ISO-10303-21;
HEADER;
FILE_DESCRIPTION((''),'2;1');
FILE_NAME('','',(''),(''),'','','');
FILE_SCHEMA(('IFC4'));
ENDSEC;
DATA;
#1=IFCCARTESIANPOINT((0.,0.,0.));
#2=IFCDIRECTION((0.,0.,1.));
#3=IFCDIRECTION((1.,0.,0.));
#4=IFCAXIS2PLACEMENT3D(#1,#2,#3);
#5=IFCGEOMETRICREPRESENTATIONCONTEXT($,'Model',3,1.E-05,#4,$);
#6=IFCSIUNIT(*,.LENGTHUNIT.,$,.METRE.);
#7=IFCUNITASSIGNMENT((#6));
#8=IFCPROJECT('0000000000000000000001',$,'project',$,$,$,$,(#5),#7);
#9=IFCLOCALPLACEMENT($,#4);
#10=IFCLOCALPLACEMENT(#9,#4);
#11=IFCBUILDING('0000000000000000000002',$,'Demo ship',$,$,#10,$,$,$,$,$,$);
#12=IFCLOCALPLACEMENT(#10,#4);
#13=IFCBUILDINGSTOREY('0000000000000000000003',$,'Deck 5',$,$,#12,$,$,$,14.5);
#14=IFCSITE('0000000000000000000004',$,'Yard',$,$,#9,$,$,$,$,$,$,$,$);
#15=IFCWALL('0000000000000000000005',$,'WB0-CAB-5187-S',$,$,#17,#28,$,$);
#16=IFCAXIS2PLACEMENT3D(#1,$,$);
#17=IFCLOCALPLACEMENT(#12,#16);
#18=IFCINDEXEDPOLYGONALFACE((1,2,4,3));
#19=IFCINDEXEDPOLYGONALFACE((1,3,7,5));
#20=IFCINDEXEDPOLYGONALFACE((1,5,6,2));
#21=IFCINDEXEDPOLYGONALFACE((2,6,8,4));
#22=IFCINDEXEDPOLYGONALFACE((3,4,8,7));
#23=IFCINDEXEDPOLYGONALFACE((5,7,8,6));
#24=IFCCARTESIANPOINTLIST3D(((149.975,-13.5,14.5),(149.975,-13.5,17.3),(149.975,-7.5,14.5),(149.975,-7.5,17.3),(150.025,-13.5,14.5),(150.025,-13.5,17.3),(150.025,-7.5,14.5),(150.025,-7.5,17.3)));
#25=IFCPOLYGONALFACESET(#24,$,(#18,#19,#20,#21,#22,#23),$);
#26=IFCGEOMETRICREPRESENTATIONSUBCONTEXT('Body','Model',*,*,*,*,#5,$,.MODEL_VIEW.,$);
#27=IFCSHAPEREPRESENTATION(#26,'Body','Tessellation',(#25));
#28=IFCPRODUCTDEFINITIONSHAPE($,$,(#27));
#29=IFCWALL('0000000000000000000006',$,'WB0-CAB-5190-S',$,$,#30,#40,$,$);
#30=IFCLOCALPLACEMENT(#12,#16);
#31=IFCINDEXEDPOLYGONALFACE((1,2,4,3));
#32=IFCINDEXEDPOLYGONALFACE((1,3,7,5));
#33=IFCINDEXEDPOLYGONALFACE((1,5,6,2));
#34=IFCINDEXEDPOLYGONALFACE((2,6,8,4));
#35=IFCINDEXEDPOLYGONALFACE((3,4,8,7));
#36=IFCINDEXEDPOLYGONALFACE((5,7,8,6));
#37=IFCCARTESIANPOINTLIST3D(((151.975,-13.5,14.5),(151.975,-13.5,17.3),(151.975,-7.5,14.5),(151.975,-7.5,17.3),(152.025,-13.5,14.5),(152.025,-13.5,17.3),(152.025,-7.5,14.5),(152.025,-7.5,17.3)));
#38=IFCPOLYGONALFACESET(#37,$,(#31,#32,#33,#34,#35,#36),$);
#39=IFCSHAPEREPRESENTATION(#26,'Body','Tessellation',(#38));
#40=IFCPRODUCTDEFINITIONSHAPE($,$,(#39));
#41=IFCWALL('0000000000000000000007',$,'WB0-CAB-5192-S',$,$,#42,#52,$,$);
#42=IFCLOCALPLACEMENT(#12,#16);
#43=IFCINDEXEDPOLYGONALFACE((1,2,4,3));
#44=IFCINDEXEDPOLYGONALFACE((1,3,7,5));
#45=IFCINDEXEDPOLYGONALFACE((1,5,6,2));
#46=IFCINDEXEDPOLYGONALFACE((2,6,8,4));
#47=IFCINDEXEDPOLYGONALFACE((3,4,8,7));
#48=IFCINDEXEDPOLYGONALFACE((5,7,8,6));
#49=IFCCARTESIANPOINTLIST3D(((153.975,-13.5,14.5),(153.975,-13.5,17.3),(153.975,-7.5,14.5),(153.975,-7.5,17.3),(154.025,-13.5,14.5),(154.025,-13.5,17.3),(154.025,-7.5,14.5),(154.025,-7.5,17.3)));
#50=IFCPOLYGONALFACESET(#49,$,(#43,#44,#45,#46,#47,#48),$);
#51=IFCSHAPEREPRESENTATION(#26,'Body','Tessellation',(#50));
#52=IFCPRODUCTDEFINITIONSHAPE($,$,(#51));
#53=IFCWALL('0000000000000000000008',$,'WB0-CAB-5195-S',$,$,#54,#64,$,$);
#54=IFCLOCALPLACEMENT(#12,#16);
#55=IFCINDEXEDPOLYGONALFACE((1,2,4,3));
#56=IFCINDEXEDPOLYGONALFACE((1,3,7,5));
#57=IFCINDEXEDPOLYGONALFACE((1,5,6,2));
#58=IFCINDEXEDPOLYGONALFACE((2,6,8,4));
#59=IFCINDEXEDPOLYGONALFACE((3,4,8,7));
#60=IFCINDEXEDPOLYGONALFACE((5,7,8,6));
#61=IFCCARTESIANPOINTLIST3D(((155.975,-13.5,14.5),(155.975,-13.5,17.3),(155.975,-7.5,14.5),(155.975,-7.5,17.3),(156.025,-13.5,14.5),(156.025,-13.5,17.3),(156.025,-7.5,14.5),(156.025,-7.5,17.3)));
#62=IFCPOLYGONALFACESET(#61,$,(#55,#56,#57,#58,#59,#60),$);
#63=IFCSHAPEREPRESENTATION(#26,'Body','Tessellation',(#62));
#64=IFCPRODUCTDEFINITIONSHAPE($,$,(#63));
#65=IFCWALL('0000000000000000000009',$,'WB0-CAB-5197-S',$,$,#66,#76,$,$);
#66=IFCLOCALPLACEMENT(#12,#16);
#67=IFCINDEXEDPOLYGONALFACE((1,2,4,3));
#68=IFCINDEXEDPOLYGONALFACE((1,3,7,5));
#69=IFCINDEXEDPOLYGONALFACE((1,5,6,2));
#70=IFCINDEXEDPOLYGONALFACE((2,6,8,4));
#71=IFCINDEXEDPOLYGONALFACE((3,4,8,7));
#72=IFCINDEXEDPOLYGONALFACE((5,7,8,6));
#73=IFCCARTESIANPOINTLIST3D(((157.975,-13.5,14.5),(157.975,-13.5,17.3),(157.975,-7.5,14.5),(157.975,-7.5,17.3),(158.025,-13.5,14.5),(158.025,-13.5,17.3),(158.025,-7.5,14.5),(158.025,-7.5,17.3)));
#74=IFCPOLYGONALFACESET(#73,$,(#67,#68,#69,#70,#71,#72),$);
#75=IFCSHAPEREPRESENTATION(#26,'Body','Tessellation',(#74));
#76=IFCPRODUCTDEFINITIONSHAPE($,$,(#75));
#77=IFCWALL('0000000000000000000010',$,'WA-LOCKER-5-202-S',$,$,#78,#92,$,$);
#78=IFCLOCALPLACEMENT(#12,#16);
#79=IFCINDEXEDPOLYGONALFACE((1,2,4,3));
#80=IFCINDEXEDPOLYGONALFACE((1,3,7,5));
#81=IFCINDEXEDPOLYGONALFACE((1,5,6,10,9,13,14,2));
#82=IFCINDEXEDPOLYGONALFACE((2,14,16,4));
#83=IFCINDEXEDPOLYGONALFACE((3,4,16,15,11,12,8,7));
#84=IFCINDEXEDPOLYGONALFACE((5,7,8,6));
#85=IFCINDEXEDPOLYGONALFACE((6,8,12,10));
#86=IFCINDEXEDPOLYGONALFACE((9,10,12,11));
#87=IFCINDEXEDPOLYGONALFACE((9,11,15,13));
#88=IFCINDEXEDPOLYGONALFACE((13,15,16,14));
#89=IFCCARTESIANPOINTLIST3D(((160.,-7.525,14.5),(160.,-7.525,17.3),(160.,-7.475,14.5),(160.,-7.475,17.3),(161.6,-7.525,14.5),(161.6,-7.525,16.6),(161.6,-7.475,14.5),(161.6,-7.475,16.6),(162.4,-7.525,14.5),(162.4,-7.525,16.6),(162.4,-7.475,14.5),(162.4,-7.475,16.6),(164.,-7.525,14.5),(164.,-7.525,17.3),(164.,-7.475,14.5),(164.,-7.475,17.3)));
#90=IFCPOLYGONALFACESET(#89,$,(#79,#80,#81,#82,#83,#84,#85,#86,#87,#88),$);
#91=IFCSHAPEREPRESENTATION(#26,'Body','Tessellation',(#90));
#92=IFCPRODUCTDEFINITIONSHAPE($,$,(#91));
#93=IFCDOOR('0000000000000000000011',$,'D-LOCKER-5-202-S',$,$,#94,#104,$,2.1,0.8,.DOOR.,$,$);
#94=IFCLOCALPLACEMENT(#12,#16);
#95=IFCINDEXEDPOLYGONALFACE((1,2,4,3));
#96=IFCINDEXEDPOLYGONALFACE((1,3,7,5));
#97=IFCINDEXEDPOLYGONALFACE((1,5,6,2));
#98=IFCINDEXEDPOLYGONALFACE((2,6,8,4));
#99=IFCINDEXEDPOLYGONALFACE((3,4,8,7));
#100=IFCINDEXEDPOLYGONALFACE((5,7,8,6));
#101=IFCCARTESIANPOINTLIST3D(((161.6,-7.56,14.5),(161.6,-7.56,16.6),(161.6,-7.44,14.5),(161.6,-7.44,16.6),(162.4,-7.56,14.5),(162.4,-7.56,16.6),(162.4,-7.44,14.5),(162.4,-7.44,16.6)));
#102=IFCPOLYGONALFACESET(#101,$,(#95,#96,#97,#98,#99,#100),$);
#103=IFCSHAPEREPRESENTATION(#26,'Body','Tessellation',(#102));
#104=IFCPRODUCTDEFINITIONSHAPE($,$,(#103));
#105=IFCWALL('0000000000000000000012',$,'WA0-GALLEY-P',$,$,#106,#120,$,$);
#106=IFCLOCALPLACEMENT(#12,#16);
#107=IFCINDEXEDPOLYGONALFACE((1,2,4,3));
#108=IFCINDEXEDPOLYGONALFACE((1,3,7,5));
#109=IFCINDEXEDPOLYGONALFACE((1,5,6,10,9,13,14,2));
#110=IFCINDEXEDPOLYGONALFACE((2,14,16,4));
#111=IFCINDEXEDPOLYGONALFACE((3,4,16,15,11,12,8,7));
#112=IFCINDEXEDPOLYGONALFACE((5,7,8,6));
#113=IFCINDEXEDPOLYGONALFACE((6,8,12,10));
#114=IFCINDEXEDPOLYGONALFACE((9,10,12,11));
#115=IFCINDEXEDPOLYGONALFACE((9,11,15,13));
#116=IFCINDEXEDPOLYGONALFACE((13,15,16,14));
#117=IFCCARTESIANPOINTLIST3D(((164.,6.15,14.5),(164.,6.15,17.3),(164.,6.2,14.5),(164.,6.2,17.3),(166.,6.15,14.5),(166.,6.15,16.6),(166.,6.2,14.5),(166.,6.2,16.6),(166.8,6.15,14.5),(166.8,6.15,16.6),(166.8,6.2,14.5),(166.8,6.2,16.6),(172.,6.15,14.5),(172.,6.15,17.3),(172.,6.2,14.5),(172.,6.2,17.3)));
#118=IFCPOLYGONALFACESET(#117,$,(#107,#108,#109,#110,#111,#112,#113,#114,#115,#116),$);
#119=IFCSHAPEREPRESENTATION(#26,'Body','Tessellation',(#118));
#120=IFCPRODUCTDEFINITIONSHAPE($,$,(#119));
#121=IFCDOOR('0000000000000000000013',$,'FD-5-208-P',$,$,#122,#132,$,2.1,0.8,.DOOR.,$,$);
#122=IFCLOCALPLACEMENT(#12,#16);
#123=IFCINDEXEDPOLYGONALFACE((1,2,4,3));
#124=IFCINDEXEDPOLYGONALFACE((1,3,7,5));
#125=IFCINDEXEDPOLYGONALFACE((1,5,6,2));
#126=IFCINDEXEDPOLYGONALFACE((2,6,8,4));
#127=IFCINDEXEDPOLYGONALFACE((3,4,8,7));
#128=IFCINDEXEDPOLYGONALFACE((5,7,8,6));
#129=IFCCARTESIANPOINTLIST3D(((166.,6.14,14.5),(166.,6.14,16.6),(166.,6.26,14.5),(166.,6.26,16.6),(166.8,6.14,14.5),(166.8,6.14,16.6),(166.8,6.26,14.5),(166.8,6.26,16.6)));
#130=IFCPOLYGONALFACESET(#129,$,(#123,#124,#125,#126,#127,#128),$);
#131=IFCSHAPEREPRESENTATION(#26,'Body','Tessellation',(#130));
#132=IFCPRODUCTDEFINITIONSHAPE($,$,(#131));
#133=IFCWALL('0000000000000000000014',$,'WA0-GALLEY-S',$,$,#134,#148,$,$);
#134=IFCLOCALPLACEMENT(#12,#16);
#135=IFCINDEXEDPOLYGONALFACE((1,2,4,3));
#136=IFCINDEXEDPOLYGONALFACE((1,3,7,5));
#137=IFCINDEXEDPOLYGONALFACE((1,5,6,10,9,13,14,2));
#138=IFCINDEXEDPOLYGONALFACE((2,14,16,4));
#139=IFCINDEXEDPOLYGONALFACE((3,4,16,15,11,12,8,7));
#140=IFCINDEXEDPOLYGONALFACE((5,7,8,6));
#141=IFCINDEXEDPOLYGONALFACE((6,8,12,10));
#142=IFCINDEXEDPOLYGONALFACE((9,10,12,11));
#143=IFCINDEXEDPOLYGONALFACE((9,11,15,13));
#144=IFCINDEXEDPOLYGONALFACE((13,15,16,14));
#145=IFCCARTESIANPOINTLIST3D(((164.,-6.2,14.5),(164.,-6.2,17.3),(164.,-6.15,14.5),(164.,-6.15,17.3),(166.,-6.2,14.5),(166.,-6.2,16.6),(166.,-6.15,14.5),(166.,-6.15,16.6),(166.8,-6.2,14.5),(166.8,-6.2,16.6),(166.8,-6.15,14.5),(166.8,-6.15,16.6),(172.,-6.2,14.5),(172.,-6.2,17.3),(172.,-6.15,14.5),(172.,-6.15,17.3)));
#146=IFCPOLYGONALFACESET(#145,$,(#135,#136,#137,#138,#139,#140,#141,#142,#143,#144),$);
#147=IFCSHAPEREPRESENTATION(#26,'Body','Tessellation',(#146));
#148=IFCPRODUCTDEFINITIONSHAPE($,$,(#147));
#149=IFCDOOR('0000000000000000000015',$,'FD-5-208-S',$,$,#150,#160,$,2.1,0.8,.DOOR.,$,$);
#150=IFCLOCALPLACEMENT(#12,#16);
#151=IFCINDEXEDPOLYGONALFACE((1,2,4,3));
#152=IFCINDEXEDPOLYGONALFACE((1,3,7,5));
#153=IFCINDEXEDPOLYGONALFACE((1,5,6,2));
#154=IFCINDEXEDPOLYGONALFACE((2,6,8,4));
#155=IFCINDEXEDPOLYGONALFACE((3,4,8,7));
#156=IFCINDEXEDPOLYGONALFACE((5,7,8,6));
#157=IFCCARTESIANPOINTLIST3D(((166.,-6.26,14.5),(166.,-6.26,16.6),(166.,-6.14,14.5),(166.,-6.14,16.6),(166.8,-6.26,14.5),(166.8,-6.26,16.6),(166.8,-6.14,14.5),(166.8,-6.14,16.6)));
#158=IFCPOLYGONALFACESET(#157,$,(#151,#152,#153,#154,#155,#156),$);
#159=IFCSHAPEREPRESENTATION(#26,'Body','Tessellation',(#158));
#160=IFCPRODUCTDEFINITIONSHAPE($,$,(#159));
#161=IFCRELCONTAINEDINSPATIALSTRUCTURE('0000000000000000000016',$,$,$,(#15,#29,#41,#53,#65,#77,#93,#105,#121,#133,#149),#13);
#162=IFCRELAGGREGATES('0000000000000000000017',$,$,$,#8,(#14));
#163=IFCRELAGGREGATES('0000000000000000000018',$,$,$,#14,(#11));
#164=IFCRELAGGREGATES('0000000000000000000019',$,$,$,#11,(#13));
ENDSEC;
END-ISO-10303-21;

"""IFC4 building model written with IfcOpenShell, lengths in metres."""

from ifc_helpers import new_model, si_unit, frame, frame_2d, origin, origin_with_axes, place, context, subcontext, project, spatial, rectangle, extrude, element, fill, save


model = new_model("IFC4")

# Units and contexts
model_context = context("Model", 3, precision=1e-05, world=origin_with_axes())
body_context = subcontext(model_context, "Body", "Model", "MODEL_VIEW")
ifc_project = project(units=[si_unit("LENGTHUNIT", "METRE")], contexts=[model_context])

# Site, building, storey
site_placement = place(None, origin_with_axes())
site = spatial("IfcSite", under=ifc_project, at=site_placement, Name="Yard")
building_placement = place(site_placement, origin_with_axes())
building = spatial("IfcBuilding", under=site, at=building_placement, Name="Demo ship")
storey_placement = place(building_placement, origin_with_axes())
storey = spatial("IfcBuildingStorey", under=building, at=storey_placement, Name="Deck 5", Elevation=14.5)

# Walls
for number, where, z_axis, x_axis, name in (
    (1, (149.975, -13.5, 14.5), (0.0, 0.0, 1.0), (1.0, 0.0, 0.0), "WB0-CAB-5187-S"),
    (2, (151.975, -13.5, 14.5), (0.0, 0.0, 1.0), (1.0, 0.0, 0.0), "WB0-CAB-5190-S"),
    (3, (153.975, -13.5, 14.5), (0.0, 0.0, 1.0), (1.0, 0.0, 0.0), "WB0-CAB-5192-S"),
    (4, (155.975, -13.5, 14.5), (0.0, 0.0, 1.0), (1.0, 0.0, 0.0), "WB0-CAB-5195-S"),
    (5, (157.975, -13.5, 14.5), (0.0, 0.0, 1.0), (1.0, 0.0, 0.0), "WB0-CAB-5197-S"),
):
    element("IfcWall", number, at=place(storey_placement, frame(where, z_axis=z_axis, x_axis=x_axis)), inside=storey, Name=name, context=body_context, shape_type="SweptSolid", body=[
        extrude(rectangle(XDim=0.05, YDim=6.0, at=frame_2d((0.025, 3.0))), origin(), (0.0, 0.0, 1.0), 2.8),
    ])

# Walls, openings, doors
wall_1_placement = place(storey_placement, frame((160.0, -7.525, 14.5), z_axis=(0.0, 0.0, 1.0), x_axis=(1.0, 0.0, 0.0)))
wall_1 = element("IfcWall", 6, at=wall_1_placement, inside=storey, Name="WA-LOCKER-5-202-S", context=body_context, shape_type="SweptSolid", body=[
    extrude(rectangle(XDim=4.0, YDim=0.05, at=frame_2d((2.0, 0.025))), origin(), (0.0, 0.0, 1.0), 2.8),
])
opening_1_placement = place(None, frame((161.6, -7.56, 14.5), z_axis=(0.0, 0.0, 1.0), x_axis=(1.0, 0.0, 0.0)))
opening_1 = element("IfcOpeningElement", 7, at=opening_1_placement, cuts=wall_1, context=body_context, shape_type="SweptSolid", body=[
    extrude(rectangle(XDim=0.8, YDim=0.12, at=frame_2d((0.4, 0.06))), origin(), (0.0, 0.0, 1.0), 2.1),
])
door_1_placement = place(storey_placement, frame((161.6, -7.56, 14.5), z_axis=(0.0, 0.0, 1.0), x_axis=(1.0, 0.0, 0.0)))
door_1 = element("IfcDoor", 8, at=door_1_placement, inside=storey, Name="D-LOCKER-5-202-S", OverallHeight=2.1, OverallWidth=0.8, PredefinedType="DOOR", context=body_context, shape_type="SweptSolid", body=[
    extrude(rectangle(XDim=0.8, YDim=0.12, at=frame_2d((0.4, 0.06))), origin(), (0.0, 0.0, 1.0), 2.1),
])
fill(opening_1, door_1)
wall_2_placement = place(storey_placement, frame((164.0, 6.15, 14.5), z_axis=(0.0, 0.0, 1.0), x_axis=(1.0, 0.0, 0.0)))
wall_2 = element("IfcWall", 9, at=wall_2_placement, inside=storey, Name="WA0-GALLEY-P", context=body_context, shape_type="SweptSolid", body=[
    extrude(rectangle(XDim=8.0, YDim=0.05, at=frame_2d((4.0, 0.025))), origin(), (0.0, 0.0, 1.0), 2.8),
])
opening_2_placement = place(None, frame((166.0, 6.14, 14.5), z_axis=(0.0, 0.0, 1.0), x_axis=(1.0, 0.0, 0.0)))
opening_2 = element("IfcOpeningElement", 10, at=opening_2_placement, cuts=wall_2, context=body_context, shape_type="SweptSolid", body=[
    extrude(rectangle(XDim=0.8, YDim=0.12, at=frame_2d((0.4, 0.06))), origin(), (0.0, 0.0, 1.0), 2.1),
])
door_2_placement = place(storey_placement, frame((166.0, 6.14, 14.5), z_axis=(0.0, 0.0, 1.0), x_axis=(1.0, 0.0, 0.0)))
door_2 = element("IfcDoor", 11, at=door_2_placement, inside=storey, Name="FD-5-208-P", OverallHeight=2.1, OverallWidth=0.8, PredefinedType="DOOR", context=body_context, shape_type="SweptSolid", body=[
    extrude(rectangle(XDim=0.8, YDim=0.12, at=frame_2d((0.4, 0.06))), origin(), (0.0, 0.0, 1.0), 2.1),
])
fill(opening_2, door_2)
wall_3_placement = place(storey_placement, frame((164.0, -6.2, 14.5), z_axis=(0.0, 0.0, 1.0), x_axis=(1.0, 0.0, 0.0)))
wall_3 = element("IfcWall", 12, at=wall_3_placement, inside=storey, Name="WA0-GALLEY-S", context=body_context, shape_type="SweptSolid", body=[
    extrude(rectangle(XDim=8.0, YDim=0.05, at=frame_2d((4.0, 0.025))), origin(), (0.0, 0.0, 1.0), 2.8),
])
opening_3_placement = place(None, frame((166.0, -6.26, 14.5), z_axis=(0.0, 0.0, 1.0), x_axis=(1.0, 0.0, 0.0)))
opening_3 = element("IfcOpeningElement", 13, at=opening_3_placement, cuts=wall_3, context=body_context, shape_type="SweptSolid", body=[
    extrude(rectangle(XDim=0.8, YDim=0.12, at=frame_2d((0.4, 0.06))), origin(), (0.0, 0.0, 1.0), 2.1),
])
door_3_placement = place(storey_placement, frame((166.0, -6.26, 14.5), z_axis=(0.0, 0.0, 1.0), x_axis=(1.0, 0.0, 0.0)))
door_3 = element("IfcDoor", 14, at=door_3_placement, inside=storey, Name="FD-5-208-S", OverallHeight=2.1, OverallWidth=0.8, PredefinedType="DOOR", context=body_context, shape_type="SweptSolid", body=[
    extrude(rectangle(XDim=0.8, YDim=0.12, at=frame_2d((0.4, 0.06))), origin(), (0.0, 0.0, 1.0), 2.1),
])
fill(opening_3, door_3)

save(model, "model.ifc")
